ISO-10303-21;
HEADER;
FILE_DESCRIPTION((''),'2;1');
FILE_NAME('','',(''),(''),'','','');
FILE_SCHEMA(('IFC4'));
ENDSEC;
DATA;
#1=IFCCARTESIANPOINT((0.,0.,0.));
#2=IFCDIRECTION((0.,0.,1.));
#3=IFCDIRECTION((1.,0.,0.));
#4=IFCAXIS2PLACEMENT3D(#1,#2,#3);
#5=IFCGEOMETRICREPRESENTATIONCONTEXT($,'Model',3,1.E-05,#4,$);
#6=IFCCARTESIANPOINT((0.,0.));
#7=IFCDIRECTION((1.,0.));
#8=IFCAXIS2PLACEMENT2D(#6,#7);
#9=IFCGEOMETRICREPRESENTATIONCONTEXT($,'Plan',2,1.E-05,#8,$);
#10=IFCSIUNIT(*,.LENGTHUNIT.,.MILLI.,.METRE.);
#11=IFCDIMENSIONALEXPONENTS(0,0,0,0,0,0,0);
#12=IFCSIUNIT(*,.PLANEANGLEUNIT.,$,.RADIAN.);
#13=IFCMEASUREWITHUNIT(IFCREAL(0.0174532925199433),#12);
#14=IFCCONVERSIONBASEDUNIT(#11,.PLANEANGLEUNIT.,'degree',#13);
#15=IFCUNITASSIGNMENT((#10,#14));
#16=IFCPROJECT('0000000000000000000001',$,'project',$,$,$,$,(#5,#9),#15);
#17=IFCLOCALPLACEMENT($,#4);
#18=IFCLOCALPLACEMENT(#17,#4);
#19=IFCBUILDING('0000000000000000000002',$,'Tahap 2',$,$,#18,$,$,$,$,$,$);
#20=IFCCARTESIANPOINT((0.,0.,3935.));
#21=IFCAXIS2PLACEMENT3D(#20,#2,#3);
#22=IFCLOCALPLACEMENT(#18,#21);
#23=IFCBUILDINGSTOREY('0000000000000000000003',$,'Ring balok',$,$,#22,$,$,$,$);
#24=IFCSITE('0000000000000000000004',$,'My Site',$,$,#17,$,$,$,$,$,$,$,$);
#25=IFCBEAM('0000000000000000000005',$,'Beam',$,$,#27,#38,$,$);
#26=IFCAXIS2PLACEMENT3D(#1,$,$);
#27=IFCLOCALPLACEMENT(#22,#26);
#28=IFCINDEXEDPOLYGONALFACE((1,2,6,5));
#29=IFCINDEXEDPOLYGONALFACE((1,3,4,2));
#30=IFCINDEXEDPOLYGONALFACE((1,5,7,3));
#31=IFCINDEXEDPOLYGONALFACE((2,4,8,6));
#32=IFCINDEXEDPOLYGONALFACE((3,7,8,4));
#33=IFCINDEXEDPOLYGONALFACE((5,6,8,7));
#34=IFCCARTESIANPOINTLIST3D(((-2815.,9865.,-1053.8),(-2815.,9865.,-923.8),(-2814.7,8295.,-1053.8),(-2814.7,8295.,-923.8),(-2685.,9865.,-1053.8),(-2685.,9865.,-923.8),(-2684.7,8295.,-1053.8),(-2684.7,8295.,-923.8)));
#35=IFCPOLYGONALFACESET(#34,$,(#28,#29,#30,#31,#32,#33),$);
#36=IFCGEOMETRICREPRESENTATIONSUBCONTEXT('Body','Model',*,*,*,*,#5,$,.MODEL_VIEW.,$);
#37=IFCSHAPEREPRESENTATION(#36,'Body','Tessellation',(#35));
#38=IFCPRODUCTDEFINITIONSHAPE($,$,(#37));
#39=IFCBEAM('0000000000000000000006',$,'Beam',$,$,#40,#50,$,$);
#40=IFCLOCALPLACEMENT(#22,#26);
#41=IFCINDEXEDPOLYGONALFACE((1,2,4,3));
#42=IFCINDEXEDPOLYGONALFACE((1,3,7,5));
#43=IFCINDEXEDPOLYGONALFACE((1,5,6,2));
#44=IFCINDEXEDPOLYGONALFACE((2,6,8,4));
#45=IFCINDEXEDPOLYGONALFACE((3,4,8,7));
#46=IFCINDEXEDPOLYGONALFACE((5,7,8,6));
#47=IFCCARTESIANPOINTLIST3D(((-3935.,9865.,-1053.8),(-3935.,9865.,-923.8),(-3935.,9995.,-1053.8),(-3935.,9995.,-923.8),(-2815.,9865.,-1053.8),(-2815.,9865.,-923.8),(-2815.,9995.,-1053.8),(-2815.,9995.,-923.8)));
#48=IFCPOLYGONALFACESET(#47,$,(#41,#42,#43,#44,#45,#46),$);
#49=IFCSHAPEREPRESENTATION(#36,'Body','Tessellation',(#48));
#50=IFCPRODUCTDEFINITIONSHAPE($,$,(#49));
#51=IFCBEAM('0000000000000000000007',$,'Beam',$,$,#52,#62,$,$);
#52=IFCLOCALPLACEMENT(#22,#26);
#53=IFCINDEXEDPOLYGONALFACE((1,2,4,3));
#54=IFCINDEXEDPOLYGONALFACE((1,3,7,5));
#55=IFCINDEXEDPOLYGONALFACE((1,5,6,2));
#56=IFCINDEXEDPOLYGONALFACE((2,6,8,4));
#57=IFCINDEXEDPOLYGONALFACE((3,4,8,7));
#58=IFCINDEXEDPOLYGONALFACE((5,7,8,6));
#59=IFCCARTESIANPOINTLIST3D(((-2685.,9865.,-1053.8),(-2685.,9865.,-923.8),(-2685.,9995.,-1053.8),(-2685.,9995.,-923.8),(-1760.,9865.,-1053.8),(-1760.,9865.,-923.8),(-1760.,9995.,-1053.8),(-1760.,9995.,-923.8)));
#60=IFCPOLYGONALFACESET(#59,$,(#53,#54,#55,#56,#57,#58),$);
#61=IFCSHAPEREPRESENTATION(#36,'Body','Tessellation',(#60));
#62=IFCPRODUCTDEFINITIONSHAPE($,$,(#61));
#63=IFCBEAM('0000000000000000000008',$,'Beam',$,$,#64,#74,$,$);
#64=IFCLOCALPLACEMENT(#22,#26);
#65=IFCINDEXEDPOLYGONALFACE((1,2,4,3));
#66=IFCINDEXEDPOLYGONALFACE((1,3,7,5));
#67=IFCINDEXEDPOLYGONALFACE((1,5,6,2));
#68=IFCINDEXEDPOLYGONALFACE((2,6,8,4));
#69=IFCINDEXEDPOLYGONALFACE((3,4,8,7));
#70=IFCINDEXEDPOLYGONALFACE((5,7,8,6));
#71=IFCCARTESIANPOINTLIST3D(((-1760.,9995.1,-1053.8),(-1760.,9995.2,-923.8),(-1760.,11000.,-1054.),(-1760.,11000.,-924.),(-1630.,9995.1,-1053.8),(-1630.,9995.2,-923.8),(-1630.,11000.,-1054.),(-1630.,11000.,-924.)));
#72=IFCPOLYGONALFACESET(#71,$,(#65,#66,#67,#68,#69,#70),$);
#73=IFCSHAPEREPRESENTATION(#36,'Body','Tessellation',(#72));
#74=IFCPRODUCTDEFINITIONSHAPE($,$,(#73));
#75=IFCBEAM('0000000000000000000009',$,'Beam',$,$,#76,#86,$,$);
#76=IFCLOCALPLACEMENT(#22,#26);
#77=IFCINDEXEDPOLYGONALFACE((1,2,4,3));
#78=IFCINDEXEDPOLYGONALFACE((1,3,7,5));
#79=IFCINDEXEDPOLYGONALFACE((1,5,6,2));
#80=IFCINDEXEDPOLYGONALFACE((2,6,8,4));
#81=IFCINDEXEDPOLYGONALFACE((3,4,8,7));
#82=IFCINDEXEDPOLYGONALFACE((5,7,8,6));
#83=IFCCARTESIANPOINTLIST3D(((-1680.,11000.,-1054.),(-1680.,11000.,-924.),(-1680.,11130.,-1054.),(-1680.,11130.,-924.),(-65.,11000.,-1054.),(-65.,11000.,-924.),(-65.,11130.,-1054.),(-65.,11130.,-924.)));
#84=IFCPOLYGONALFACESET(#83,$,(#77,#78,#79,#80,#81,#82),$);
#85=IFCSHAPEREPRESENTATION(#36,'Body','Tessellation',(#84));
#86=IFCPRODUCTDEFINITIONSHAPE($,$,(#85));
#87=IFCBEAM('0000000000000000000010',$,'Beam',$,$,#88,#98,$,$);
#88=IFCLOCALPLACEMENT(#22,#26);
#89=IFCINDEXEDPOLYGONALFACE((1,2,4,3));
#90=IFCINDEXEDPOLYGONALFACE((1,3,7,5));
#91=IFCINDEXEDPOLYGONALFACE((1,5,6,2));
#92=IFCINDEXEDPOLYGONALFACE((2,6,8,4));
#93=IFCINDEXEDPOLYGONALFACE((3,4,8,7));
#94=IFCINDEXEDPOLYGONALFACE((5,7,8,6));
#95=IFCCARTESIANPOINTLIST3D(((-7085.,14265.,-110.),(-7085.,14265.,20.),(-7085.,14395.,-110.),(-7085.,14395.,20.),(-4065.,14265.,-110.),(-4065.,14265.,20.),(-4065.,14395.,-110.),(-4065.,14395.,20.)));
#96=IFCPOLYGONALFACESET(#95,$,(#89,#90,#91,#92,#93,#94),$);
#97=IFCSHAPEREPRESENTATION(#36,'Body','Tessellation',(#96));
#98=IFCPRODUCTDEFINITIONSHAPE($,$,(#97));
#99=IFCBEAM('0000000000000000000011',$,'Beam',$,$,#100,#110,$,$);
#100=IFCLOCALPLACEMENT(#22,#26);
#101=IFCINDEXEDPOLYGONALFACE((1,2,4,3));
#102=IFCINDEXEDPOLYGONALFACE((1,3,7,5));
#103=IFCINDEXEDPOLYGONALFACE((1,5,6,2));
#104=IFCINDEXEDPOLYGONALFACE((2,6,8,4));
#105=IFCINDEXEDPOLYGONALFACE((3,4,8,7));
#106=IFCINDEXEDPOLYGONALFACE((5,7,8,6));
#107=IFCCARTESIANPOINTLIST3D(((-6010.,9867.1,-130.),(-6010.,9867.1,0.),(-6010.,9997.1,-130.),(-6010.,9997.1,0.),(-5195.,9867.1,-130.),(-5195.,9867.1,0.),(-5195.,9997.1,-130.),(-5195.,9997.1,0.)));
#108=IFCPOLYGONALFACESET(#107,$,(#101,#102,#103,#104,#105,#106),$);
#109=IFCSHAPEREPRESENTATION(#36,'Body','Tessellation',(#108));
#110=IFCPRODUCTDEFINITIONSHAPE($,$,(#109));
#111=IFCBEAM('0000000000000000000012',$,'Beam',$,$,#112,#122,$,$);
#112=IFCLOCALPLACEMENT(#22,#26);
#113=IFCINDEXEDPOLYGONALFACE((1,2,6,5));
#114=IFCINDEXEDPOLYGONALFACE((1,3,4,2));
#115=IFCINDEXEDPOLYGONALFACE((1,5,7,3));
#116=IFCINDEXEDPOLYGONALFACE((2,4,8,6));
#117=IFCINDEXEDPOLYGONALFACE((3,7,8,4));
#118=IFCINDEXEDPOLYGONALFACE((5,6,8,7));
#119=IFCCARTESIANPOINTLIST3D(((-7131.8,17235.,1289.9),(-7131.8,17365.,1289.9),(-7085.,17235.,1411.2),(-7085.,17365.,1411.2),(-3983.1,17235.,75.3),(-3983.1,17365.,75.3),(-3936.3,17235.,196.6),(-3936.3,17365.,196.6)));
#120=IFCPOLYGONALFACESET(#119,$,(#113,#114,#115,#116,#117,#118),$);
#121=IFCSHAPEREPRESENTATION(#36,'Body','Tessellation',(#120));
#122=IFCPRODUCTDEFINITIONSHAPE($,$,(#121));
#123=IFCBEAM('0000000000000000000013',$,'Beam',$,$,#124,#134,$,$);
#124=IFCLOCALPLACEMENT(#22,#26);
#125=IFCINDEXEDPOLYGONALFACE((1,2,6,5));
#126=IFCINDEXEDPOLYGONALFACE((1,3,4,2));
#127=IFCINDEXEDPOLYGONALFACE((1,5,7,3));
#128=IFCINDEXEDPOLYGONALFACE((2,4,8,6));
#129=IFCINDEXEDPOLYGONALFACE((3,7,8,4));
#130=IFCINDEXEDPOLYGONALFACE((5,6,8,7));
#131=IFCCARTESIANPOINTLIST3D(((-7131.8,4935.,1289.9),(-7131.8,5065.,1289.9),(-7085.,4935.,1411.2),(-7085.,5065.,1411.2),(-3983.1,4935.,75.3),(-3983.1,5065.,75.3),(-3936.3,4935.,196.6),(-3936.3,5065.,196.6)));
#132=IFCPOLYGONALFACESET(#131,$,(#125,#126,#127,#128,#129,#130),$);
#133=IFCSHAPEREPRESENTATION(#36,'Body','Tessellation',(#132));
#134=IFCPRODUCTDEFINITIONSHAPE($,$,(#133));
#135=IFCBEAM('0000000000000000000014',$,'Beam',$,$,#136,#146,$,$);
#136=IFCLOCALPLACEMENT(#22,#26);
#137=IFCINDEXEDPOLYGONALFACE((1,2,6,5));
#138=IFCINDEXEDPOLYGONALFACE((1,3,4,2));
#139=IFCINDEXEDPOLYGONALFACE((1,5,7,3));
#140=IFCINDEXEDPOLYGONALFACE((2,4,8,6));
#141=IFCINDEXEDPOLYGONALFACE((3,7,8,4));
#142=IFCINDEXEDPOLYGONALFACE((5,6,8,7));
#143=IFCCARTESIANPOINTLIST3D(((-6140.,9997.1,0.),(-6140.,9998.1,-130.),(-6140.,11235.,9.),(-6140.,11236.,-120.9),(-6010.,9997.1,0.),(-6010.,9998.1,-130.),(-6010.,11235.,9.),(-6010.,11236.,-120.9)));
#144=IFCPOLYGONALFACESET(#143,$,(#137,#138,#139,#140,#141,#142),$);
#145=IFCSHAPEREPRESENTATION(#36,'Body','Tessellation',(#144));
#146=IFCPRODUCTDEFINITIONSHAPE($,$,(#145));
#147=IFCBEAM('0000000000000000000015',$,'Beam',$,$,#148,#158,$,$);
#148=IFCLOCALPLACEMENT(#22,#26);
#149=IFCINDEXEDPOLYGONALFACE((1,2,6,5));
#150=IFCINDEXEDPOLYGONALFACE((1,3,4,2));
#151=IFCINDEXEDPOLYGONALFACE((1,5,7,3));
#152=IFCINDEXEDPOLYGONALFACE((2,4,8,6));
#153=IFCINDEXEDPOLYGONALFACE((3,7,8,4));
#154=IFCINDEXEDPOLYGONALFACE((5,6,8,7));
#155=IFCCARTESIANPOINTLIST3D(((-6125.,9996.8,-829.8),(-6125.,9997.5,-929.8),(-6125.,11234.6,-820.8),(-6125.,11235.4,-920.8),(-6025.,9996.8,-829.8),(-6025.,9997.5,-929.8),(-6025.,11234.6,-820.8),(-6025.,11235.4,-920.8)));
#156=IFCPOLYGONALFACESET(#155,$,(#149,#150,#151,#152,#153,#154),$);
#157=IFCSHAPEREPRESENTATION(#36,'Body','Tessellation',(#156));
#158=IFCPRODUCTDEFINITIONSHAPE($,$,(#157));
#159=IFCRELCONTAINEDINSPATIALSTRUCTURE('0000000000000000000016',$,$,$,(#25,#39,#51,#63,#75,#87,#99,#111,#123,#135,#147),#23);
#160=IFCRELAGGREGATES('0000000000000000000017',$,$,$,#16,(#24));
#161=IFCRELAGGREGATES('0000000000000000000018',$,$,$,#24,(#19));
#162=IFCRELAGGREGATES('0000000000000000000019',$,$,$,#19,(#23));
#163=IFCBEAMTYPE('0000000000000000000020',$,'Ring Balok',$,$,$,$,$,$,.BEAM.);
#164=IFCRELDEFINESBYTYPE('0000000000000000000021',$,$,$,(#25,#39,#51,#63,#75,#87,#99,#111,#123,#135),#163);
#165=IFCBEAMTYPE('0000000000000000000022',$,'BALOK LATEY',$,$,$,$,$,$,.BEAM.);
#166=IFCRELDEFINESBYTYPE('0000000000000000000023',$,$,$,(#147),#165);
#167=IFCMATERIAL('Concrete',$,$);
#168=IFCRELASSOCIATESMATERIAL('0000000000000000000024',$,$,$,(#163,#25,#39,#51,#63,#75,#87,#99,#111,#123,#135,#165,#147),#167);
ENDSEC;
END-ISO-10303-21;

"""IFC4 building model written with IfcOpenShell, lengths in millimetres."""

from ifc_helpers import new_model, entity, si_unit, converted_unit, frame, origin_with_axes, origin_2d_with_axis, place, context, subcontext, project, spatial, rectangle, extrude, material, material_profile, profile_set, profile_usage, type_object, element, save


model = new_model("IFC4")

# Units and contexts
model_context = context("Model", 3, precision=1e-05, world=origin_with_axes())
plan_context = context("Plan", 2, precision=1e-05, world=origin_2d_with_axis())
body_context = subcontext(model_context, "Body", "Model", "MODEL_VIEW")
ifc_project = project(units=[si_unit("LENGTHUNIT", "METRE", prefix="MILLI"), converted_unit("PLANEANGLEUNIT", "degree", entity("IfcReal", 0.0174532925199433), si_unit("PLANEANGLEUNIT", "RADIAN"), dimensions=[0, 0, 0, 0, 0, 0, 0])], contexts=[model_context, plan_context])

# Site, building, storey
site_placement = place(None, origin_with_axes())
site = spatial("IfcSite", under=ifc_project, at=site_placement, Name="My Site")
building_placement = place(site_placement, origin_with_axes())
building = spatial("IfcBuilding", under=site, at=building_placement, Name="Tahap 2")
storey_placement = place(building_placement, frame((0.0, 0.0, 3935.0), z_axis=(0.0, 0.0, 1.0), x_axis=(1.0, 0.0, 0.0)))
storey = spatial("IfcBuildingStorey", under=building, at=storey_placement, Name="Ring balok")

# Beams
ifc_material = material(Name="Concrete")
ifc_material_profile_1 = material_profile(ifc_material, rectangle(XDim=130.0, YDim=130.0))
ifc_profile_set_1 = profile_set([ifc_material_profile_1])
beam_type_1 = type_object("IfcBeamType", Name="Ring Balok", PredefinedType="BEAM", material=ifc_profile_set_1)
ifc_profile_usage_1 = profile_usage(ifc_profile_set_1, cardinal=9)
beam_1_placement = place(storey_placement, frame((-2684.7, 8295.0, -923.8), z_axis=(-0.000202, 1.0, 0.0), x_axis=(-1.0, -0.000202, 0.0)))
element("IfcBeam", 1, at=beam_1_placement, inside=storey, type_object=beam_type_1, material=ifc_profile_usage_1, Name="Beam", context=body_context, shape_type="SweptSolid", body=[
    extrude(rectangle(XDim=130.0, YDim=130.0), frame((65.0, -65.0, 0.0), z_axis=(0.0, 0.0, 1.0), x_axis=(1.0, 0.0, 0.0)), (0.0, 0.0, 1.0), 1570.0),
])
ifc_profile_usage_2 = profile_usage(ifc_profile_set_1, cardinal=9)
beam_2_placement = place(storey_placement, frame((-3935.0, 9865.0, -923.8), z_axis=(1.0, -0.000023, 0.0), x_axis=(0.000023, 1.0, 0.0)))
element("IfcBeam", 2, at=beam_2_placement, inside=storey, type_object=beam_type_1, material=ifc_profile_usage_2, Name="Beam", context=body_context, shape_type="SweptSolid", body=[
    extrude(rectangle(XDim=130.0, YDim=130.0), frame((65.0, -65.0, 0.0), z_axis=(0.0, 0.0, 1.0), x_axis=(1.0, 0.0, 0.0)), (0.0, 0.0, 1.0), 1120.0),
])
ifc_profile_usage_3 = profile_usage(ifc_profile_set_1, cardinal=9)
beam_3_placement = place(storey_placement, frame((-2685.0, 9865.0, -923.8), z_axis=(1.0, 0.000001, 0.0), x_axis=(-0.000001, 1.0, 0.0)))
element("IfcBeam", 3, at=beam_3_placement, inside=storey, type_object=beam_type_1, material=ifc_profile_usage_3, Name="Beam", context=body_context, shape_type="SweptSolid", body=[
    extrude(rectangle(XDim=130.0, YDim=130.0), frame((65.0, -65.0, 0.0), z_axis=(0.0, 0.0, 1.0), x_axis=(1.0, 0.0, 0.0)), (0.0, 0.0, 1.0), 925.0),
])
ifc_profile_usage_4 = profile_usage(ifc_profile_set_1, cardinal=9)
beam_4_placement = place(storey_placement, frame((-1630.0, 9995.2, -923.8), z_axis=(0.0, 1.0, -0.000242), x_axis=(-1.0, 0.0, 0.0)))
element("IfcBeam", 4, at=beam_4_placement, inside=storey, type_object=beam_type_1, material=ifc_profile_usage_4, Name="Beam", context=body_context, shape_type="SweptSolid", body=[
    extrude(rectangle(XDim=130.0, YDim=130.0), frame((65.0, -65.0, 0.0), z_axis=(0.0, 0.0, 1.0), x_axis=(1.0, 0.0, 0.0)), (0.0, 0.0, 1.0), 1004.8),
])
ifc_profile_usage_5 = profile_usage(ifc_profile_set_1, cardinal=9)
beam_5_placement = place(storey_placement, frame((-1680.0, 11000.0, -924.0), z_axis=(1.0, 0.0, 0.0), x_axis=(0.0, 1.0, 0.0)))
element("IfcBeam", 5, at=beam_5_placement, inside=storey, type_object=beam_type_1, material=ifc_profile_usage_5, Name="Beam", context=body_context, shape_type="SweptSolid", body=[
    extrude(rectangle(XDim=130.0, YDim=130.0), frame((65.0, -65.0, 0.0), z_axis=(0.0, 0.0, 1.0), x_axis=(1.0, 0.0, 0.0)), (0.0, 0.0, 1.0), 1615.0),
])
ifc_profile_usage_6 = profile_usage(ifc_profile_set_1, cardinal=9)
beam_6_placement = place(storey_placement, frame((-4065.0, 14395.0, 20.0), z_axis=(-1.0, 0.0, 0.0), x_axis=(0.0, -1.0, 0.0)))
element("IfcBeam", 6, at=beam_6_placement, inside=storey, type_object=beam_type_1, material=ifc_profile_usage_6, Name="Beam", context=body_context, shape_type="SweptSolid", body=[
    extrude(rectangle(XDim=130.0, YDim=130.0), frame((65.0, -65.0, 0.0), z_axis=(0.0, 0.0, 1.0), x_axis=(1.0, 0.0, 0.0)), (0.0, 0.0, 1.0), 3020.0),
])
ifc_profile_usage_7 = profile_usage(ifc_profile_set_1, cardinal=9)
beam_7_placement = place(storey_placement, frame((-6010.0, 9867.1, 0.0), z_axis=(1.0, 0.000001, 0.000006), x_axis=(-0.000001, 1.0, 0.0)))
element("IfcBeam", 7, at=beam_7_placement, inside=storey, type_object=beam_type_1, material=ifc_profile_usage_7, Name="Beam", context=body_context, shape_type="SweptSolid", body=[
    extrude(rectangle(XDim=130.0, YDim=130.0), frame((65.0, -65.0, 0.0), z_axis=(0.0, 0.0, 1.0), x_axis=(1.0, 0.0, 0.0)), (0.0, 0.0, 1.0), 815.0),
])
ifc_profile_usage_8 = profile_usage(ifc_profile_set_1, cardinal=9)
beam_8_placement = place(storey_placement, frame((-7085.0, 17235.0, 1411.2), z_axis=(0.93299, 0.0, -0.359903), x_axis=(0.0, 1.0, 0.0)))
element("IfcBeam", 8, at=beam_8_placement, inside=storey, type_object=beam_type_1, material=ifc_profile_usage_8, Name="Beam", context=body_context, shape_type="SweptSolid", body=[
    extrude(rectangle(XDim=130.0, YDim=130.0), frame((65.0, -65.0, 0.0), z_axis=(0.0, 0.0, 1.0), x_axis=(1.0, 0.0, 0.0)), (0.0, 0.0, 1.0), 3374.9),
])
ifc_profile_usage_9 = profile_usage(ifc_profile_set_1, cardinal=9)
beam_9_placement = place(storey_placement, frame((-7085.0, 4935.0, 1411.2), z_axis=(0.93299, 0.0, -0.359903), x_axis=(0.0, 1.0, 0.0)))
element("IfcBeam", 9, at=beam_9_placement, inside=storey, type_object=beam_type_1, material=ifc_profile_usage_9, Name="Beam", context=body_context, shape_type="SweptSolid", body=[
    extrude(rectangle(XDim=130.0, YDim=130.0), frame((65.0, -65.0, 0.0), z_axis=(0.0, 0.0, 1.0), x_axis=(1.0, 0.0, 0.0)), (0.0, 0.0, 1.0), 3374.9),
])
ifc_profile_usage_10 = profile_usage(ifc_profile_set_1, cardinal=9)
beam_10_placement = place(storey_placement, frame((-6010.0, 9997.1, 0.0), z_axis=(0.0, 0.999973, 0.00731), x_axis=(-1.0, 0.0, 0.0)))
element("IfcBeam", 10, at=beam_10_placement, inside=storey, type_object=beam_type_1, material=ifc_profile_usage_10, Name="Beam", context=body_context, shape_type="SweptSolid", body=[
    extrude(rectangle(XDim=130.0, YDim=130.0), frame((65.0, -65.0, 0.0), z_axis=(0.0, 0.0, 1.0), x_axis=(1.0, 0.0, 0.0)), (0.0, 0.0, 1.0), 1237.9),
])
ifc_material_profile_2 = material_profile(ifc_material, rectangle(XDim=100.0, YDim=100.0))
ifc_profile_set_2 = profile_set([ifc_material_profile_2])
ifc_profile_usage_11 = profile_usage(ifc_profile_set_2)
beam_type_2 = type_object("IfcBeamType", Name="BALOK LATEY", PredefinedType="BEAM", material=ifc_profile_set_2)
beam_11_placement = place(storey_placement, frame((-6075.0, 9997.1, -879.8), z_axis=(0.0, 0.999973, 0.00731), x_axis=(-1.0, 0.0, 0.0)))
element("IfcBeam", 11, at=beam_11_placement, inside=storey, type_object=beam_type_2, material=ifc_profile_usage_11, Name="Beam", context=body_context, shape_type="SweptSolid", body=[
    extrude(rectangle(XDim=100.0, YDim=100.0), origin_with_axes(), (0.0, 0.0, 1.0), 1237.9),
])

save(model, "model.ifc")
